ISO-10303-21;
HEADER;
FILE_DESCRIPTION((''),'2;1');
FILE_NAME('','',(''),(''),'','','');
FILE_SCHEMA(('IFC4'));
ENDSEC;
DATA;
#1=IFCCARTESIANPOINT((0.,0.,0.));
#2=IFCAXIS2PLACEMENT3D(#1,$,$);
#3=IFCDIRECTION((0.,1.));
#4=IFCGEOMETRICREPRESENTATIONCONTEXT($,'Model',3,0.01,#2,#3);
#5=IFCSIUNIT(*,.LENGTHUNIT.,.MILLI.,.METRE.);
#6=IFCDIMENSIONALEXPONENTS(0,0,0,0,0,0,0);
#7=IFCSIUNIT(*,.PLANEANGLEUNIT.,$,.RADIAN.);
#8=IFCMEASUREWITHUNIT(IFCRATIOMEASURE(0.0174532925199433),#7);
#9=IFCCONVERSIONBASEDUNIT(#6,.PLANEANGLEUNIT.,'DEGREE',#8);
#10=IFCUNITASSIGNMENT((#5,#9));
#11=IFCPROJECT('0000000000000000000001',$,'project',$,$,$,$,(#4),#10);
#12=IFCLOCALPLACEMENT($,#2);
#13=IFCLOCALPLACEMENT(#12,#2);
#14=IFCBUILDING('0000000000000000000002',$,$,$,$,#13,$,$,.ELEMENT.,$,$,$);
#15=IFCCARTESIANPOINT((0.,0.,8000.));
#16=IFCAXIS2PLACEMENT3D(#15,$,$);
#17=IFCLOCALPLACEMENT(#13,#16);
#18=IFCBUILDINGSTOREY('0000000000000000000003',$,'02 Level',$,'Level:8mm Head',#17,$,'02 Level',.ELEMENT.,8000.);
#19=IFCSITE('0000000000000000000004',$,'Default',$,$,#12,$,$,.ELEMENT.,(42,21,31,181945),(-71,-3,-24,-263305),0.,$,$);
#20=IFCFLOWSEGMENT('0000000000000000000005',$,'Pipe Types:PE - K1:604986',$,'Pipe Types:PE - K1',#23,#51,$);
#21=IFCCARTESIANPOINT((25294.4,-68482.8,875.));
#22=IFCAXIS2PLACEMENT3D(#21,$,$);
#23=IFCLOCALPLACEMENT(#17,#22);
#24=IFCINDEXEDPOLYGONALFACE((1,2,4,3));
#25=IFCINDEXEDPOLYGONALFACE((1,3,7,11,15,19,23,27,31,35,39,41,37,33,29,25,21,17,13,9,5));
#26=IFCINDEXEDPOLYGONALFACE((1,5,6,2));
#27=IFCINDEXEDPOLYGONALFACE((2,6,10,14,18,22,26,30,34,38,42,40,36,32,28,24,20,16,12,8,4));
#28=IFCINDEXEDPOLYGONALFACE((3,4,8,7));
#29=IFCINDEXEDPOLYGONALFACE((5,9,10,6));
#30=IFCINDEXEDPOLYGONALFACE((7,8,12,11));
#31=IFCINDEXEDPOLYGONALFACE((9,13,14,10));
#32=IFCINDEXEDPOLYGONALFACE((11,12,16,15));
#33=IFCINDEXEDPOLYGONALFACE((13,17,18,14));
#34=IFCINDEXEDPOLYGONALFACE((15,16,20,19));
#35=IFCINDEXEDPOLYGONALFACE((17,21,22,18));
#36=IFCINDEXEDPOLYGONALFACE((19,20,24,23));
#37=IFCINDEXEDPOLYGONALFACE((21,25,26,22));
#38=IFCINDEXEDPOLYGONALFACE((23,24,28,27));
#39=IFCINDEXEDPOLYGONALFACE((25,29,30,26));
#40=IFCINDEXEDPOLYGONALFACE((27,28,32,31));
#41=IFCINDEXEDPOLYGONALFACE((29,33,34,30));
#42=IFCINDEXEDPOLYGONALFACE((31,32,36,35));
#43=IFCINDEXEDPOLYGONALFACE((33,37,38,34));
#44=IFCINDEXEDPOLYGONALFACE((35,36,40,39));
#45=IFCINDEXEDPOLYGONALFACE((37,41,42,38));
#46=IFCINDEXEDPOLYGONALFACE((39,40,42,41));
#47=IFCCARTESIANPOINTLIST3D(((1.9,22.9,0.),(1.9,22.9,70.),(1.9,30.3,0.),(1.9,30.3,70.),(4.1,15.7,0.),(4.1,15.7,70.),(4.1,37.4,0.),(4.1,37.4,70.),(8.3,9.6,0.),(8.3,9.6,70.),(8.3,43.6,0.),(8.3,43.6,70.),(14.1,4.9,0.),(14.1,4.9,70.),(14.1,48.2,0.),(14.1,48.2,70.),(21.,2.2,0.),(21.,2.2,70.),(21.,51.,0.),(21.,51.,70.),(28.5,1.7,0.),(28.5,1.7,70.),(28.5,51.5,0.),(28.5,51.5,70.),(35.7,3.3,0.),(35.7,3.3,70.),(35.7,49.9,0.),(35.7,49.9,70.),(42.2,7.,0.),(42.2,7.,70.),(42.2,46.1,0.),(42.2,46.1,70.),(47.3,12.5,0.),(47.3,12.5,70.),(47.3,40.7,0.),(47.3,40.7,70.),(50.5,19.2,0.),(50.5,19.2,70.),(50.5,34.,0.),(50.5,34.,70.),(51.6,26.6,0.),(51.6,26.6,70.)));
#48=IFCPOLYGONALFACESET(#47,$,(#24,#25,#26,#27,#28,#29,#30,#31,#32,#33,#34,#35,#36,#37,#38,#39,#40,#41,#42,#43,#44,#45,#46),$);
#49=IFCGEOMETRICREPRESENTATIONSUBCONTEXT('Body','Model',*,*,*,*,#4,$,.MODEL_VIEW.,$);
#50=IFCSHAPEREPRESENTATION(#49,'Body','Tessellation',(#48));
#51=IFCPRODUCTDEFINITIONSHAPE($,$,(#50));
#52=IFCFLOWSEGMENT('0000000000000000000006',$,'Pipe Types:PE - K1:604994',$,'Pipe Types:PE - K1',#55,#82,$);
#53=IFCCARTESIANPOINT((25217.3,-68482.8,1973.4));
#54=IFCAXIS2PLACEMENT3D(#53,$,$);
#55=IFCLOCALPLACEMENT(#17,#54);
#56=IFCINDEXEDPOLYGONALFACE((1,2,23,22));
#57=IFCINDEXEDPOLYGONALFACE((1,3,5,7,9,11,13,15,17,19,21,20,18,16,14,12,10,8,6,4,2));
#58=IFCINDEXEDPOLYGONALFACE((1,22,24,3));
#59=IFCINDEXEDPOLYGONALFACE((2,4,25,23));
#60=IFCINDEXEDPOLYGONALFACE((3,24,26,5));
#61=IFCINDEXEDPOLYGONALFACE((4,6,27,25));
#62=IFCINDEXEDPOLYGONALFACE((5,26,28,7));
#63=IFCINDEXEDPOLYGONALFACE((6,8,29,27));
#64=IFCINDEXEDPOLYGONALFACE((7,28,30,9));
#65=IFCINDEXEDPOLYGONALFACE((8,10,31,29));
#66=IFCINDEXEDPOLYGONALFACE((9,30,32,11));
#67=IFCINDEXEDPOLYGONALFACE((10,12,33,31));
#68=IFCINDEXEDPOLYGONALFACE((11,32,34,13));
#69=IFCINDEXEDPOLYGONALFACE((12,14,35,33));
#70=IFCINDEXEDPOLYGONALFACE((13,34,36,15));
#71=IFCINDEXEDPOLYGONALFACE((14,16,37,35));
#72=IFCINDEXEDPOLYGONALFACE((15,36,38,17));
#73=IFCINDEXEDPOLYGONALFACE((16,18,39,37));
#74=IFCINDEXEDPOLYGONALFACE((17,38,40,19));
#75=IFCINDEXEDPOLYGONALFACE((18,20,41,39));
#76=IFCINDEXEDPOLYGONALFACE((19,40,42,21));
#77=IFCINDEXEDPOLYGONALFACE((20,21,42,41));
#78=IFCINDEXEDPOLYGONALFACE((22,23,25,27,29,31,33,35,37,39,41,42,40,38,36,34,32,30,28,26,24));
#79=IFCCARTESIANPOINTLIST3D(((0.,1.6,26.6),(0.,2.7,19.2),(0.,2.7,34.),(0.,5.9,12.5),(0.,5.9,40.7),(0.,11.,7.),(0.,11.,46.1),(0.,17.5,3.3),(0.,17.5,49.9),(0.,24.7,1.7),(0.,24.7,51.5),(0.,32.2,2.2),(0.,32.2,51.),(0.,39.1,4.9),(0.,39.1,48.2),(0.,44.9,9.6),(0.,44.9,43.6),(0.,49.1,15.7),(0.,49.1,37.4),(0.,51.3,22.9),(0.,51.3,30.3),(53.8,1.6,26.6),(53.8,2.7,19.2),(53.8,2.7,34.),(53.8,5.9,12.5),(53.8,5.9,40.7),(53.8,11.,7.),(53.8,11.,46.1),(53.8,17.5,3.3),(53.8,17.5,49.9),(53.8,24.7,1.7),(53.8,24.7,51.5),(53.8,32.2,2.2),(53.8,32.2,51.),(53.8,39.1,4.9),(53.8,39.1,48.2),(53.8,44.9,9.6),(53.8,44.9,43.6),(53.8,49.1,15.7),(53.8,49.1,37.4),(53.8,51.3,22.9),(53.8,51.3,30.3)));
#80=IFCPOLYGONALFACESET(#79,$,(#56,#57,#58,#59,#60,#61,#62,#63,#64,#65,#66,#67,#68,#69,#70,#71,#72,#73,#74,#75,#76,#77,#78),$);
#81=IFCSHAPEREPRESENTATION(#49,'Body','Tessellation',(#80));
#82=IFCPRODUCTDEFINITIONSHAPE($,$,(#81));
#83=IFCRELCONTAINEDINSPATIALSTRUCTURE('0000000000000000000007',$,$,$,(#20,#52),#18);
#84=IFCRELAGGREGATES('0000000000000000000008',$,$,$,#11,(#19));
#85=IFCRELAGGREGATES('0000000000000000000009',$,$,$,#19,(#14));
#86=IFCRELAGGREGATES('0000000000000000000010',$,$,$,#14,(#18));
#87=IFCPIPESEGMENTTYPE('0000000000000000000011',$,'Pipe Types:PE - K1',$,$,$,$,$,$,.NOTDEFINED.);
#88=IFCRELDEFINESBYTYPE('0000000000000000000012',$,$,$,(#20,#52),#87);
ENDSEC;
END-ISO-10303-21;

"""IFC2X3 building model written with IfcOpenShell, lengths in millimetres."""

from ifc_helpers import new_model, entity, si_unit, converted_unit, direction, frame, frame_2d, origin, origin_2d_with_axis, place, context, subcontext, project, spatial, circle, extrude, type_object, element, save


model = new_model("IFC2X3")

# Units and contexts
model_context = context("Model", 3, precision=0.01, world=origin(), true_north=direction((0.0, 1.0)))
body_context = subcontext(model_context, "Body", "Model", "MODEL_VIEW")
ifc_project = project(units=[si_unit("LENGTHUNIT", "METRE", prefix="MILLI"), converted_unit("PLANEANGLEUNIT", "DEGREE", entity("IfcRatioMeasure", 0.0174532925199433), si_unit("PLANEANGLEUNIT", "RADIAN"), dimensions=[0, 0, 0, 0, 0, 0, 0])], contexts=[model_context])

# Site, building, storey
site_placement = place(None, origin())
site = spatial("IfcSite", under=ifc_project, at=site_placement, Name="Default", CompositionType="ELEMENT", RefLatitude=(42, 21, 31, 181945), RefLongitude=(-71, -3, -24, -263305), RefElevation=0.0)
building_placement = place(site_placement, origin())
building = spatial("IfcBuilding", under=site, at=building_placement, CompositionType="ELEMENT")
storey_placement = place(building_placement, frame((0.0, 0.0, 8000.0)))
storey = spatial("IfcBuildingStorey", under=building, at=storey_placement, Name="02 Level", ObjectType="Level:8mm Head", LongName="02 Level", CompositionType="ELEMENT", Elevation=8000.0)

# Flow segments
pipe_segment_type_1 = type_object("IfcPipeSegmentType", Name="Pipe Types:PE - K1", PredefinedType="NOTDEFINED")
flow_segment_1_placement = place(storey_placement, frame((25294.4, -68482.8, 875.0)))
element("IfcFlowSegment", 1, at=flow_segment_1_placement, inside=storey, type_object=pipe_segment_type_1, Name="Pipe Types:PE - K1:604986", ObjectType="Pipe Types:PE - K1", context=body_context, shape_type="SweptSolid", body=[
    extrude(circle(Radius=25.0, at=origin_2d_with_axis()), frame((26.6, 26.6, 0.0)), (0.0, 0.0, 1.0), 70.0),
])
flow_segment_2_placement = place(storey_placement, frame((25217.3, -68482.8, 1973.4)))
element("IfcFlowSegment", 2, at=flow_segment_2_placement, inside=storey, type_object=pipe_segment_type_1, Name="Pipe Types:PE - K1:604994", ObjectType="Pipe Types:PE - K1", context=body_context, shape_type="SweptSolid", body=[
    extrude(circle(Radius=25.0, at=frame_2d((0.0, 0.0), x_axis=(1.0, 0.0))), frame((0.0, 26.6, 26.6), z_axis=(1.0, 0.0, 0.0), x_axis=(0.0, -1.0, 0.0)), (0.0, 0.0, 1.0), 53.8),
])

save(model, "model.ifc")
